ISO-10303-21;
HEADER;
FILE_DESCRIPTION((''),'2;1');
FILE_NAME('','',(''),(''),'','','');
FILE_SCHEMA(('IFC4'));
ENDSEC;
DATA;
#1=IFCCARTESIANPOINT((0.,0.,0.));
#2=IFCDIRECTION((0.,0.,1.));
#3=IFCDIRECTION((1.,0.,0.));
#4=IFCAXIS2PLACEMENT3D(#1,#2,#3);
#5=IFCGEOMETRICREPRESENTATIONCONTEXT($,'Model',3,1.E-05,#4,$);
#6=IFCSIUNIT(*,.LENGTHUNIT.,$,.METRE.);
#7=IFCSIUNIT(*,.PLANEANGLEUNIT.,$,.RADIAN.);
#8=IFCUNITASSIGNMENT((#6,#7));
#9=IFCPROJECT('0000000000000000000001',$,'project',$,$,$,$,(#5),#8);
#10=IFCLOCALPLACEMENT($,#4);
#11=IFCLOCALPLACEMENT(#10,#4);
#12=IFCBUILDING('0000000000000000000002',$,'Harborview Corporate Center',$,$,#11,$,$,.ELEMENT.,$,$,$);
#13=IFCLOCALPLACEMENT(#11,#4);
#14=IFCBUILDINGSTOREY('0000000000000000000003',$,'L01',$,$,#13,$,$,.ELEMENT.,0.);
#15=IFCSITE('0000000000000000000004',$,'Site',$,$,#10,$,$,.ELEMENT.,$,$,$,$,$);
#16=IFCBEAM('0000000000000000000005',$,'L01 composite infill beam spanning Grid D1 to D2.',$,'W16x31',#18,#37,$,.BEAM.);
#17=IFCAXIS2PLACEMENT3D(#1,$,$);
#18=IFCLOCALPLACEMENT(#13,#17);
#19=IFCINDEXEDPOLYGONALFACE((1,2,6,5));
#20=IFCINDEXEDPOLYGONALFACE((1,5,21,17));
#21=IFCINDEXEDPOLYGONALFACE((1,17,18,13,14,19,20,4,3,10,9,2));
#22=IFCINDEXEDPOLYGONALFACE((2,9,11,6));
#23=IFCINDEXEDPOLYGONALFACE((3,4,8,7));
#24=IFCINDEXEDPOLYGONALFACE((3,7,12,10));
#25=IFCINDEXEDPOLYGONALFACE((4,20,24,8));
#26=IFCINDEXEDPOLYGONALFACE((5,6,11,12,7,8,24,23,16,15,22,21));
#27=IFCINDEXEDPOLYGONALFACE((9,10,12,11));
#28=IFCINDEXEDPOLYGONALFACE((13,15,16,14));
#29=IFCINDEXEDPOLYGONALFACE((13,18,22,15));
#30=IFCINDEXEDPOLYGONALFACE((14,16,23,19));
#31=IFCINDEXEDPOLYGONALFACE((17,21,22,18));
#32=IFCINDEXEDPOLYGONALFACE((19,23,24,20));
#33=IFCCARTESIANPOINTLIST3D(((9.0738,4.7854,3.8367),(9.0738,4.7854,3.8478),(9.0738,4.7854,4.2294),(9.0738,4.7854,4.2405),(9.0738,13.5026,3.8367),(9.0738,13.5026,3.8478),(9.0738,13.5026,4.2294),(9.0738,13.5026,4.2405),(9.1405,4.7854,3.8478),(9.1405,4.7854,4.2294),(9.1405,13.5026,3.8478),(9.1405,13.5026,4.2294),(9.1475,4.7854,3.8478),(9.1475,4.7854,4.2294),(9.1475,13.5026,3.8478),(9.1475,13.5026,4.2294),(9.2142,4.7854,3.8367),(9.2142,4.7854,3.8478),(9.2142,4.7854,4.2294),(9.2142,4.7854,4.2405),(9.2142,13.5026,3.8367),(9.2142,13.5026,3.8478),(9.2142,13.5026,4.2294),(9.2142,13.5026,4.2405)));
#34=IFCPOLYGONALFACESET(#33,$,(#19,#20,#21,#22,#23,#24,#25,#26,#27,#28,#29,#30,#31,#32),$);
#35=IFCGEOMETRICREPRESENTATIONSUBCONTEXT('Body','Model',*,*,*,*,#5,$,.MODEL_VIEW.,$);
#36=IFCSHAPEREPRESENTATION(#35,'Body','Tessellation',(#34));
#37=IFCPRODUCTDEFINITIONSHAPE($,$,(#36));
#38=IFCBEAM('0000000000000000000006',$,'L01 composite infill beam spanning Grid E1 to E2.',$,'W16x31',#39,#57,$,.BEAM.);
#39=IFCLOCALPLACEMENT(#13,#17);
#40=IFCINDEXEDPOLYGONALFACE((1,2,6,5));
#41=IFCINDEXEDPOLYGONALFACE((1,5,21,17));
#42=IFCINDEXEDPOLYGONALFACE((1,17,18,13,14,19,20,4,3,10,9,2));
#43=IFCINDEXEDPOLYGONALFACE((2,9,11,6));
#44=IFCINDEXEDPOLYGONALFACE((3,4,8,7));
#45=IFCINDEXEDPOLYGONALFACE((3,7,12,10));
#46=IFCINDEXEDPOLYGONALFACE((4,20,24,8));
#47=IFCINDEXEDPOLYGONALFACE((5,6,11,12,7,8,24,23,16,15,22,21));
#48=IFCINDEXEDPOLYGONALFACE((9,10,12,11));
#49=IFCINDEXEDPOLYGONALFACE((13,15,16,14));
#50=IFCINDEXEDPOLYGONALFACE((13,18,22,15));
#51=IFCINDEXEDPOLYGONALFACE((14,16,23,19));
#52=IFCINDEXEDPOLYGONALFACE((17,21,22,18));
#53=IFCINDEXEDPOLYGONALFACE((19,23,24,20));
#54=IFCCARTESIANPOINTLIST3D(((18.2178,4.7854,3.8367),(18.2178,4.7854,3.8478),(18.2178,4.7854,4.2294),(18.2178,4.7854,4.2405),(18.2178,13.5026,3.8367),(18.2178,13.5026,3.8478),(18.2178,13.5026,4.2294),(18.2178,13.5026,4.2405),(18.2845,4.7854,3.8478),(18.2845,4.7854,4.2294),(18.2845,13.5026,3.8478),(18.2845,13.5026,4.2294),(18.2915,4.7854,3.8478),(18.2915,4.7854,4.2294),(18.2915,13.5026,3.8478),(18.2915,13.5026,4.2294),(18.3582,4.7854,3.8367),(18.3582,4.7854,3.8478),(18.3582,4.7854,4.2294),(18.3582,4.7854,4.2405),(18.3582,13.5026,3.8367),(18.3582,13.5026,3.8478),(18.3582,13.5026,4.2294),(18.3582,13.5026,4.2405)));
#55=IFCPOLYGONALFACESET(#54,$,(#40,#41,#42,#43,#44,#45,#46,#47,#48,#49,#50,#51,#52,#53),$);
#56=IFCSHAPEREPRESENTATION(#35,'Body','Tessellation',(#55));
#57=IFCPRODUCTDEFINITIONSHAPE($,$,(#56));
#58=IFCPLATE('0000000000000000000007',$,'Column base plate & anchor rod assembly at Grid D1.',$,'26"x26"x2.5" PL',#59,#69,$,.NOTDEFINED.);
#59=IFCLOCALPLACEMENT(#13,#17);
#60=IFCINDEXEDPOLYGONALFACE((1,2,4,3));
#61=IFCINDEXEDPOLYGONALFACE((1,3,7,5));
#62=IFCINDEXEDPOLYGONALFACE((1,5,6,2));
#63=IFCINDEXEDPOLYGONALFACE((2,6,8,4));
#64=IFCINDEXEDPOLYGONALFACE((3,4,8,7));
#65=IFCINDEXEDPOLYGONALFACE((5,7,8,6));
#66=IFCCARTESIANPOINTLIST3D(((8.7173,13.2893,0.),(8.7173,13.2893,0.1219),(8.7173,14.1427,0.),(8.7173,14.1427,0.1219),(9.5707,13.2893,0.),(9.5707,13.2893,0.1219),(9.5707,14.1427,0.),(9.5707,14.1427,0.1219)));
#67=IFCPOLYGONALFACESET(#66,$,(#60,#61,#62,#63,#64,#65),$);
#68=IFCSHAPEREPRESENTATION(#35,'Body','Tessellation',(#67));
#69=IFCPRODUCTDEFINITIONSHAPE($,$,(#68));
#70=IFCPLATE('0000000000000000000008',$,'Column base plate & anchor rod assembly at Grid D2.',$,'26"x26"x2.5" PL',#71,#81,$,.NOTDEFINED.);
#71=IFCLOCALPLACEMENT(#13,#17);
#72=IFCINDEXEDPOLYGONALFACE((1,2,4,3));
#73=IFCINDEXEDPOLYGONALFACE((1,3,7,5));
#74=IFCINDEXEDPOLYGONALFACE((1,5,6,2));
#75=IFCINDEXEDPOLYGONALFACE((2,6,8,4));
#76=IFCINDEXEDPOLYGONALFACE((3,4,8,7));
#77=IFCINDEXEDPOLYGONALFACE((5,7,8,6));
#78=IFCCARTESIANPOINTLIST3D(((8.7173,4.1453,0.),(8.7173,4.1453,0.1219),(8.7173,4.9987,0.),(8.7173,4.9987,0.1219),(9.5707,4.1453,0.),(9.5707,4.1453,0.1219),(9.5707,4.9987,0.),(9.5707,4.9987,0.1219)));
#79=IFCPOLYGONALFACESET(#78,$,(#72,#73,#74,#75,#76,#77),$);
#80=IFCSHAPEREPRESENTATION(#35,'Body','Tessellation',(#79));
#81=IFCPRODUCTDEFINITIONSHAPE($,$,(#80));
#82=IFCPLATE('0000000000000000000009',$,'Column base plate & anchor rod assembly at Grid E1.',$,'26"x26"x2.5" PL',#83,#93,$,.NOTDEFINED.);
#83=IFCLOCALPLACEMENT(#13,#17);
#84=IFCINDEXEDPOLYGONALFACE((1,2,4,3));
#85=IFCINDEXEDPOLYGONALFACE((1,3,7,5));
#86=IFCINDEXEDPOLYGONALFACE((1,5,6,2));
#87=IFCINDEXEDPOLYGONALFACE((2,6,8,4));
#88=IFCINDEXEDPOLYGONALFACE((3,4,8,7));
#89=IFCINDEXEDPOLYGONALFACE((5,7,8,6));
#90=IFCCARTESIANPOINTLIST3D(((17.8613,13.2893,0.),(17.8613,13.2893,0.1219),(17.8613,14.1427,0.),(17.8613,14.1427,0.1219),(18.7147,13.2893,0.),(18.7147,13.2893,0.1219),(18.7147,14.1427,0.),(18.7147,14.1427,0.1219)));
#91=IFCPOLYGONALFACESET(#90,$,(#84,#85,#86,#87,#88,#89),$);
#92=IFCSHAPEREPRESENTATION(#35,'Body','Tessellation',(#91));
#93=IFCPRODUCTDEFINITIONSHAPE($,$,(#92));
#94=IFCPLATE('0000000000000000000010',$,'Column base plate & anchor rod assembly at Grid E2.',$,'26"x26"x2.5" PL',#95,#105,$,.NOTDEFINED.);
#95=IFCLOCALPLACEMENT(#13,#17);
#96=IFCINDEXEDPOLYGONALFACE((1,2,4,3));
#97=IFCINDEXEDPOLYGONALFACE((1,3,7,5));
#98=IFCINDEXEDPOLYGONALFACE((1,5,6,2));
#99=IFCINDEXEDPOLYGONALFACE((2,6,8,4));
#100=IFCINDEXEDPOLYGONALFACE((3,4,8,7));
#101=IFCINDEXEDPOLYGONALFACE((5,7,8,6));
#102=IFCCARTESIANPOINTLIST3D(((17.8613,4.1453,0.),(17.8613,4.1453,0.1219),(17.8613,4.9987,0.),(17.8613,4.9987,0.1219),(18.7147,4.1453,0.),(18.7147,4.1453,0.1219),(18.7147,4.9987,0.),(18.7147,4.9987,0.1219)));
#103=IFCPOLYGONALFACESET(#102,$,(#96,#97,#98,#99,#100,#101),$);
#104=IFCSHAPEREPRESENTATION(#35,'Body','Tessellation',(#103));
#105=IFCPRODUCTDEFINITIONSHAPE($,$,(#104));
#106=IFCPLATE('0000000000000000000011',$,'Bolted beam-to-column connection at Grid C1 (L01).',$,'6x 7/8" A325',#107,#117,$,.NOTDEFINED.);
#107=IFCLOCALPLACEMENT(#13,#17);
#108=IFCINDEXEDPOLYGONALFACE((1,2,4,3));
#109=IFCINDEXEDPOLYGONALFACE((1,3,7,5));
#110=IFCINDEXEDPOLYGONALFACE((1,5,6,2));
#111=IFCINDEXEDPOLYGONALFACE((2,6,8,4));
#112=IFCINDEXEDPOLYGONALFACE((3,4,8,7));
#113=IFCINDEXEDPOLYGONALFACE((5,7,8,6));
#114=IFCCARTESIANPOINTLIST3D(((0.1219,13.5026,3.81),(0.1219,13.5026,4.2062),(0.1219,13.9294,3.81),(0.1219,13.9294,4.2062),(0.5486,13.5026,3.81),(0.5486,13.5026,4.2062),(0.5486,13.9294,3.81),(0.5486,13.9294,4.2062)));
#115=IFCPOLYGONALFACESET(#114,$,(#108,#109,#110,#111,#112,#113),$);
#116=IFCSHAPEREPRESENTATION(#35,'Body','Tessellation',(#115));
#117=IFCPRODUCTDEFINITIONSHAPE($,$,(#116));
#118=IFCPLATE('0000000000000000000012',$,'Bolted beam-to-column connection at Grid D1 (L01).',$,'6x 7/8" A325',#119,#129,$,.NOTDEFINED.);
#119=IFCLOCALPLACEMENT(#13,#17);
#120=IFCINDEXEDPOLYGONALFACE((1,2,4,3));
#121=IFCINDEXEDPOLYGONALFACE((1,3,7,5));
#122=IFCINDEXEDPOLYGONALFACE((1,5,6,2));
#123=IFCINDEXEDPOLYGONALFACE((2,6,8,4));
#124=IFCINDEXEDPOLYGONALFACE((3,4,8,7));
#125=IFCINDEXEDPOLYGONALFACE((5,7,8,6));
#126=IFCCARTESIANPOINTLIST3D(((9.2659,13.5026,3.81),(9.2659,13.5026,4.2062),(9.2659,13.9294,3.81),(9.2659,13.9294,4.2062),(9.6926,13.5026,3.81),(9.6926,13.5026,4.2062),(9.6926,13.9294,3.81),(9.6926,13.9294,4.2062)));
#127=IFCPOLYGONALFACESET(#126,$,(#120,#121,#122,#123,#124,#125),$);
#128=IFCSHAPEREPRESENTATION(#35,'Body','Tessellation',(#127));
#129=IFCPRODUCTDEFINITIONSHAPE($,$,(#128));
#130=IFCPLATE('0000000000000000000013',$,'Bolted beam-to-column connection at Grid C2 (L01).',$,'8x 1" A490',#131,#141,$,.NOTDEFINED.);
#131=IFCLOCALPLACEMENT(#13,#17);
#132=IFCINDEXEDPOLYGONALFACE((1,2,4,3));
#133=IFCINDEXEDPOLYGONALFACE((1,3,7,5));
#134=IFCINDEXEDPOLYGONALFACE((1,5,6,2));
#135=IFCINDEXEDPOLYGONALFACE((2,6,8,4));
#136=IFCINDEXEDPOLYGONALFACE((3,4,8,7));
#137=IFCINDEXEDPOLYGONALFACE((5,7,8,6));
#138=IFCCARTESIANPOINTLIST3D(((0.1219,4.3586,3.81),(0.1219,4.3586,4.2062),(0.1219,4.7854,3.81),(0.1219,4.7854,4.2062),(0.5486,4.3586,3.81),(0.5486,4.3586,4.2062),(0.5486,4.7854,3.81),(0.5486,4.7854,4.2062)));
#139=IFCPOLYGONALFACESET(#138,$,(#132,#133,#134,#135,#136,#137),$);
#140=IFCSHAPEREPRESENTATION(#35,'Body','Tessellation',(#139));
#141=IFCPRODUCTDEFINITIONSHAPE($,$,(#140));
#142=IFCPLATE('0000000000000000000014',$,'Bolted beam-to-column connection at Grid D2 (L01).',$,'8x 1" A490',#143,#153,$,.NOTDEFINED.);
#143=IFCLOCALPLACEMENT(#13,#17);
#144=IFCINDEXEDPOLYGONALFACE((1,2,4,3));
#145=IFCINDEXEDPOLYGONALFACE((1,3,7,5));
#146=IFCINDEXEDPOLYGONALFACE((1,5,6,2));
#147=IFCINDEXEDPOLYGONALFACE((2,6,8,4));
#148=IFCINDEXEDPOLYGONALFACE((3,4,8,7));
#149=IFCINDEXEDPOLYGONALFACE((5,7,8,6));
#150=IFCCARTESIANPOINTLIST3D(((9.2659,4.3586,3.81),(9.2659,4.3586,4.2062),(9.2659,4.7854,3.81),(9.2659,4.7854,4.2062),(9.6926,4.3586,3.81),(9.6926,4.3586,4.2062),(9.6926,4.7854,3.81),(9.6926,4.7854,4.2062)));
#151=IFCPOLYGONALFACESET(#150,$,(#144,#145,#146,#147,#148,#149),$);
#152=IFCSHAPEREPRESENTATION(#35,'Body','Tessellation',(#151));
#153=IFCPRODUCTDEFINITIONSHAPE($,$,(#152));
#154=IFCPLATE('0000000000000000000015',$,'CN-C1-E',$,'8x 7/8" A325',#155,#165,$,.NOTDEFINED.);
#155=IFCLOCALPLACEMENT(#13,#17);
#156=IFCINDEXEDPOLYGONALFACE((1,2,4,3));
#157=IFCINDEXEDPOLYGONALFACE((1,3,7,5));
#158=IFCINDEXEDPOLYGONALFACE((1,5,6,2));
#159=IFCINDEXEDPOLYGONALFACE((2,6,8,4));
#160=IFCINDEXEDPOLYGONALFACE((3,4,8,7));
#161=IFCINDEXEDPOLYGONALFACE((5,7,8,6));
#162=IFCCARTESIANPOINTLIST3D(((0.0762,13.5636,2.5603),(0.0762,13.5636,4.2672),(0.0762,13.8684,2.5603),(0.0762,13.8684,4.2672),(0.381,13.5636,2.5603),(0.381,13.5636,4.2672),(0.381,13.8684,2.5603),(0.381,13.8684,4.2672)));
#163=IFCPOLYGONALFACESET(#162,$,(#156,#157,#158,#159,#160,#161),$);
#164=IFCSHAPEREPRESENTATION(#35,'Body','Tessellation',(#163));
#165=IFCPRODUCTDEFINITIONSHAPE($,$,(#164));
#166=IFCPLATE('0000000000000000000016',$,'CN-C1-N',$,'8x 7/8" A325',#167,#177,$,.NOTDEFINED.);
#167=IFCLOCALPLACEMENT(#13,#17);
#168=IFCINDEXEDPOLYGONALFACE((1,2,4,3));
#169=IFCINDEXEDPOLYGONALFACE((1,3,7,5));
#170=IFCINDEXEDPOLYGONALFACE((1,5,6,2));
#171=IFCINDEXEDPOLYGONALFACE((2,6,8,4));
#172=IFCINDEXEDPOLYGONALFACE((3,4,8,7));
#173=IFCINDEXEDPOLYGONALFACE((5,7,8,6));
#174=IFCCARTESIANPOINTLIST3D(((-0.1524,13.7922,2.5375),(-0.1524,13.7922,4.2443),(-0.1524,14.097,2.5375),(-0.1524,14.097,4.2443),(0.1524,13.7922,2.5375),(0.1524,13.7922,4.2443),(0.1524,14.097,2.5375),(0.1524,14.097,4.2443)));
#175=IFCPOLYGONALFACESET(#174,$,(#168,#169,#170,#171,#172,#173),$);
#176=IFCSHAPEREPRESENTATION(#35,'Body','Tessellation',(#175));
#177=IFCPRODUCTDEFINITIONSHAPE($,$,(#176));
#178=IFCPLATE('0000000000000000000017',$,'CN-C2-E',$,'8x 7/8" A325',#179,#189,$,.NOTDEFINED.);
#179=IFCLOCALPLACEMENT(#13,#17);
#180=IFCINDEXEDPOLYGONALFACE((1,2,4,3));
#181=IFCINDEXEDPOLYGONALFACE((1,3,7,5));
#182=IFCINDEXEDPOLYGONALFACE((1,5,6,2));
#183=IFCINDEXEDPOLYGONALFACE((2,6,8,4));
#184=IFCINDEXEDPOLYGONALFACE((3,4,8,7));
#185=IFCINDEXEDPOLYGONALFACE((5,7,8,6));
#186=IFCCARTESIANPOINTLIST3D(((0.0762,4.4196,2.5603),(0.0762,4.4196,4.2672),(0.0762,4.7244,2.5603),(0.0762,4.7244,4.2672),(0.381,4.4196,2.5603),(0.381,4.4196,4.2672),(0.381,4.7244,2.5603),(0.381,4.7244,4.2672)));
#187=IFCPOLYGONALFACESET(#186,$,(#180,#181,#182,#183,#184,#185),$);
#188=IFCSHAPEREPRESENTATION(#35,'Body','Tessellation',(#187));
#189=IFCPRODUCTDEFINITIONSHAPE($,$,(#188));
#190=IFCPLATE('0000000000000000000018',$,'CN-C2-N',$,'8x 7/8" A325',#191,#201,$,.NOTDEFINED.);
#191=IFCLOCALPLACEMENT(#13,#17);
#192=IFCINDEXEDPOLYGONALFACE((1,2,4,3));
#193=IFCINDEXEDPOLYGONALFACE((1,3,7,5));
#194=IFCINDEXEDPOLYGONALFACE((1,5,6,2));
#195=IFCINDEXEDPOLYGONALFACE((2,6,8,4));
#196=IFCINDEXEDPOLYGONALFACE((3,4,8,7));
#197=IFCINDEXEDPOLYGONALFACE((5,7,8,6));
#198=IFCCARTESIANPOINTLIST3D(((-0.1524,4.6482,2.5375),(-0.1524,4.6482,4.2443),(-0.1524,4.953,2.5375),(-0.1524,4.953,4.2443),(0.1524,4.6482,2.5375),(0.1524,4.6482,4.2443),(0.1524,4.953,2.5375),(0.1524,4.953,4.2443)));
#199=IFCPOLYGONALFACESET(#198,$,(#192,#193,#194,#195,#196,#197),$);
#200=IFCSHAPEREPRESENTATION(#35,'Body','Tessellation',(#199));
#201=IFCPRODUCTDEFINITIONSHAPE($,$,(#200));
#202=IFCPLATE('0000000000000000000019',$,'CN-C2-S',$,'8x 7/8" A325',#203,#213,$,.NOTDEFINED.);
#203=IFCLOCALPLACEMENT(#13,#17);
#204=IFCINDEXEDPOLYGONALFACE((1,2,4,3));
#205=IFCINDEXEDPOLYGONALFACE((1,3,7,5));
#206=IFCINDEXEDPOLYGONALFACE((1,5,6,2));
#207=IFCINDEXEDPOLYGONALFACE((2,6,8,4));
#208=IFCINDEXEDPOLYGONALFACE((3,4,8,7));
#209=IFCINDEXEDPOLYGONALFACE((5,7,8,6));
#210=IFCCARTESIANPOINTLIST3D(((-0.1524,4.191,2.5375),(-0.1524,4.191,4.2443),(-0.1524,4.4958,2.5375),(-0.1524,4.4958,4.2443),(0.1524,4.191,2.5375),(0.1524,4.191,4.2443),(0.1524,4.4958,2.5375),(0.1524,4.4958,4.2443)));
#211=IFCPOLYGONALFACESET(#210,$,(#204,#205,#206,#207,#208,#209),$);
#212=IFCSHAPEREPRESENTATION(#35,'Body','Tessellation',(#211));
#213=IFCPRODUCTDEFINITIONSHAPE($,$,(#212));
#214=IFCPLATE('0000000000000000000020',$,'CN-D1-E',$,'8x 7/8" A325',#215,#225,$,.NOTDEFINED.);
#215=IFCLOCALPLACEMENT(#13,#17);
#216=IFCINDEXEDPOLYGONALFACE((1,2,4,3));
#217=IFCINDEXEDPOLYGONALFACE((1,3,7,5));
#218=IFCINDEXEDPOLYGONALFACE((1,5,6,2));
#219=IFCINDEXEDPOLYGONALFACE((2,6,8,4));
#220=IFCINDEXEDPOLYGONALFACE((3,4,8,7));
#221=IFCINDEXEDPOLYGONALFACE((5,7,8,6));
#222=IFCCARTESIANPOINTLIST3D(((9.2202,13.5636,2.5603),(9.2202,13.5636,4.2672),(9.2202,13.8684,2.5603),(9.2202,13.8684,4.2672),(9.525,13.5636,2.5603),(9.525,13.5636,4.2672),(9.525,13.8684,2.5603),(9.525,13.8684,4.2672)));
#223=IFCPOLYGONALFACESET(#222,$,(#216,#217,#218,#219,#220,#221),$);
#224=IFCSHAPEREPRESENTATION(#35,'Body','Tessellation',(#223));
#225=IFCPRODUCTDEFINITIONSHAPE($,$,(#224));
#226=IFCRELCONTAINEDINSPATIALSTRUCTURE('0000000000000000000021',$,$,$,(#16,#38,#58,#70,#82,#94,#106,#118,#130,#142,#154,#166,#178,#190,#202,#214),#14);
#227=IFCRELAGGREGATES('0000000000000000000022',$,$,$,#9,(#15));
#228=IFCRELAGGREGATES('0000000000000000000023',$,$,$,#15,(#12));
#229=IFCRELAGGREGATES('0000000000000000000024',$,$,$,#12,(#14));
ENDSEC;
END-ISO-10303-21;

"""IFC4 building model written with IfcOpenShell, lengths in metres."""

from ifc_helpers import new_model, si_unit, frame, origin_with_axes, place, context, subcontext, project, spatial, rectangle, i_section, extrude, element, save


model = new_model("IFC4")

# Units and contexts
model_context = context("Model", 3, precision=1e-05, world=origin_with_axes())
body_context = subcontext(model_context, "Body", "Model", "MODEL_VIEW")
ifc_project = project(units=[si_unit("LENGTHUNIT", "METRE"), si_unit("PLANEANGLEUNIT", "RADIAN")], contexts=[model_context])

# Site, building, storey
site_placement = place(None, origin_with_axes())
site = spatial("IfcSite", under=ifc_project, at=site_placement, Name="Site", CompositionType="ELEMENT")
building_placement = place(site_placement, origin_with_axes())
building = spatial("IfcBuilding", under=site, at=building_placement, Name="Harborview Corporate Center", CompositionType="ELEMENT")
storey_placement = place(building_placement, origin_with_axes())
storey = spatial("IfcBuildingStorey", under=building, at=storey_placement, Name="L01", CompositionType="ELEMENT", Elevation=0.0)

# Beams
for number, where, z_axis, x_axis, name in (
    (1, (9.144, 4.7854, 4.0386), (0.0, 1.0, 0.0), (-1.0, 0.0, 0.0), "L01 composite infill beam spanning Grid D1 to D2."),
    (2, (18.288, 4.7854, 4.0386), (0.0, 1.0, 0.0), (-1.0, 0.0, 0.0), "L01 composite infill beam spanning Grid E1 to E2."),
):
    element("IfcBeam", number, at=place(storey_placement, frame(where, z_axis=z_axis, x_axis=x_axis)), inside=storey, Name=name, ObjectType="W16x31", PredefinedType="BEAM", context=body_context, shape_type="SweptSolid", body=[
        extrude(i_section(OverallWidth=0.1405, OverallDepth=0.4039, WebThickness=0.007, FlangeThickness=0.0112), origin_with_axes(), (0.0, 0.0, 1.0), 8.7173),
    ])

# Plates
plate_1_placement = place(storey_placement, frame((9.144, 13.716, 0.0), z_axis=(0.0, 0.0, 1.0), x_axis=(1.0, 0.0, 0.0)))
element("IfcPlate", 3, at=plate_1_placement, inside=storey, Name="Column base plate & anchor rod assembly at Grid D1.", ObjectType="26\"x26\"x2.5\" PL", PredefinedType="NOTDEFINED", context=body_context, shape_type="SweptSolid", body=[
    extrude(rectangle(XDim=0.8534, YDim=0.8534), origin_with_axes(), (0.0, 0.0, 1.0), 0.1219),
])
plate_2_placement = place(storey_placement, frame((9.144, 4.572, 0.0), z_axis=(0.0, 0.0, 1.0), x_axis=(1.0, 0.0, 0.0)))
element("IfcPlate", 4, at=plate_2_placement, inside=storey, Name="Column base plate & anchor rod assembly at Grid D2.", ObjectType="26\"x26\"x2.5\" PL", PredefinedType="NOTDEFINED", context=body_context, shape_type="SweptSolid", body=[
    extrude(rectangle(XDim=0.8534, YDim=0.8534), origin_with_axes(), (0.0, 0.0, 1.0), 0.1219),
])
plate_3_placement = place(storey_placement, frame((18.288, 13.716, 0.0), z_axis=(0.0, 0.0, 1.0), x_axis=(1.0, 0.0, 0.0)))
element("IfcPlate", 5, at=plate_3_placement, inside=storey, Name="Column base plate & anchor rod assembly at Grid E1.", ObjectType="26\"x26\"x2.5\" PL", PredefinedType="NOTDEFINED", context=body_context, shape_type="SweptSolid", body=[
    extrude(rectangle(XDim=0.8534, YDim=0.8534), origin_with_axes(), (0.0, 0.0, 1.0), 0.1219),
])
plate_4_placement = place(storey_placement, frame((18.288, 4.572, 0.0), z_axis=(0.0, 0.0, 1.0), x_axis=(1.0, 0.0, 0.0)))
element("IfcPlate", 6, at=plate_4_placement, inside=storey, Name="Column base plate & anchor rod assembly at Grid E2.", ObjectType="26\"x26\"x2.5\" PL", PredefinedType="NOTDEFINED", context=body_context, shape_type="SweptSolid", body=[
    extrude(rectangle(XDim=0.8534, YDim=0.8534), origin_with_axes(), (0.0, 0.0, 1.0), 0.1219),
])
plate_5_placement = place(storey_placement, frame((0.3353, 13.716, 3.81), z_axis=(0.0, 0.0, 1.0), x_axis=(1.0, 0.0, 0.0)))
element("IfcPlate", 7, at=plate_5_placement, inside=storey, Name="Bolted beam-to-column connection at Grid C1 (L01).", ObjectType="6x 7/8\" A325", PredefinedType="NOTDEFINED", context=body_context, shape_type="SweptSolid", body=[
    extrude(rectangle(XDim=0.4267, YDim=0.4267), origin_with_axes(), (0.0, 0.0, 1.0), 0.3962),
])
plate_6_placement = place(storey_placement, frame((9.4793, 13.716, 3.81), z_axis=(0.0, 0.0, 1.0), x_axis=(1.0, 0.0, 0.0)))
element("IfcPlate", 8, at=plate_6_placement, inside=storey, Name="Bolted beam-to-column connection at Grid D1 (L01).", ObjectType="6x 7/8\" A325", PredefinedType="NOTDEFINED", context=body_context, shape_type="SweptSolid", body=[
    extrude(rectangle(XDim=0.4267, YDim=0.4267), origin_with_axes(), (0.0, 0.0, 1.0), 0.3962),
])
plate_7_placement = place(storey_placement, frame((0.3353, 4.572, 3.81), z_axis=(0.0, 0.0, 1.0), x_axis=(1.0, 0.0, 0.0)))
element("IfcPlate", 9, at=plate_7_placement, inside=storey, Name="Bolted beam-to-column connection at Grid C2 (L01).", ObjectType="8x 1\" A490", PredefinedType="NOTDEFINED", context=body_context, shape_type="SweptSolid", body=[
    extrude(rectangle(XDim=0.4267, YDim=0.4267), origin_with_axes(), (0.0, 0.0, 1.0), 0.3962),
])
plate_8_placement = place(storey_placement, frame((9.4793, 4.572, 3.81), z_axis=(0.0, 0.0, 1.0), x_axis=(1.0, 0.0, 0.0)))
element("IfcPlate", 10, at=plate_8_placement, inside=storey, Name="Bolted beam-to-column connection at Grid D2 (L01).", ObjectType="8x 1\" A490", PredefinedType="NOTDEFINED", context=body_context, shape_type="SweptSolid", body=[
    extrude(rectangle(XDim=0.4267, YDim=0.4267), origin_with_axes(), (0.0, 0.0, 1.0), 0.3962),
])
for number, where, z_axis, x_axis, name in (
    (11, (0.2286, 13.716, 2.5603), (0.0, 0.0, 1.0), (1.0, 0.0, 0.0), "CN-C1-E"),
    (12, (0.0, 13.9446, 2.5375), (0.0, 0.0, 1.0), (1.0, 0.0, 0.0), "CN-C1-N"),
    (13, (0.2286, 4.572, 2.5603), (0.0, 0.0, 1.0), (1.0, 0.0, 0.0), "CN-C2-E"),
    (14, (0.0, 4.8006, 2.5375), (0.0, 0.0, 1.0), (1.0, 0.0, 0.0), "CN-C2-N"),
    (15, (0.0, 4.3434, 2.5375), (0.0, 0.0, 1.0), (1.0, 0.0, 0.0), "CN-C2-S"),
):
    element("IfcPlate", number, at=place(storey_placement, frame(where, z_axis=z_axis, x_axis=x_axis)), inside=storey, Name=name, ObjectType="8x 7/8\" A325", PredefinedType="NOTDEFINED", context=body_context, shape_type="SweptSolid", body=[
        extrude(rectangle(XDim=0.3048, YDim=0.3048), origin_with_axes(), (0.0, 0.0, 1.0), 1.7069),
    ])
for number, where, z_axis, x_axis, name in (
    (16, (9.3726, 13.716, 2.5603), (0.0, 0.0, 1.0), (1.0, 0.0, 0.0), "CN-D1-E"),
):
    element("IfcPlate", number, at=place(storey_placement, frame(where, z_axis=z_axis, x_axis=x_axis)), inside=storey, Name=name, ObjectType="8x 7/8\" A325", PredefinedType="NOTDEFINED", context=body_context, shape_type="SweptSolid", body=[
        extrude(rectangle(XDim=0.3048, YDim=0.3048), origin_with_axes(), (0.0, 0.0, 1.0), 1.7069),
    ])

save(model, "model.ifc")
